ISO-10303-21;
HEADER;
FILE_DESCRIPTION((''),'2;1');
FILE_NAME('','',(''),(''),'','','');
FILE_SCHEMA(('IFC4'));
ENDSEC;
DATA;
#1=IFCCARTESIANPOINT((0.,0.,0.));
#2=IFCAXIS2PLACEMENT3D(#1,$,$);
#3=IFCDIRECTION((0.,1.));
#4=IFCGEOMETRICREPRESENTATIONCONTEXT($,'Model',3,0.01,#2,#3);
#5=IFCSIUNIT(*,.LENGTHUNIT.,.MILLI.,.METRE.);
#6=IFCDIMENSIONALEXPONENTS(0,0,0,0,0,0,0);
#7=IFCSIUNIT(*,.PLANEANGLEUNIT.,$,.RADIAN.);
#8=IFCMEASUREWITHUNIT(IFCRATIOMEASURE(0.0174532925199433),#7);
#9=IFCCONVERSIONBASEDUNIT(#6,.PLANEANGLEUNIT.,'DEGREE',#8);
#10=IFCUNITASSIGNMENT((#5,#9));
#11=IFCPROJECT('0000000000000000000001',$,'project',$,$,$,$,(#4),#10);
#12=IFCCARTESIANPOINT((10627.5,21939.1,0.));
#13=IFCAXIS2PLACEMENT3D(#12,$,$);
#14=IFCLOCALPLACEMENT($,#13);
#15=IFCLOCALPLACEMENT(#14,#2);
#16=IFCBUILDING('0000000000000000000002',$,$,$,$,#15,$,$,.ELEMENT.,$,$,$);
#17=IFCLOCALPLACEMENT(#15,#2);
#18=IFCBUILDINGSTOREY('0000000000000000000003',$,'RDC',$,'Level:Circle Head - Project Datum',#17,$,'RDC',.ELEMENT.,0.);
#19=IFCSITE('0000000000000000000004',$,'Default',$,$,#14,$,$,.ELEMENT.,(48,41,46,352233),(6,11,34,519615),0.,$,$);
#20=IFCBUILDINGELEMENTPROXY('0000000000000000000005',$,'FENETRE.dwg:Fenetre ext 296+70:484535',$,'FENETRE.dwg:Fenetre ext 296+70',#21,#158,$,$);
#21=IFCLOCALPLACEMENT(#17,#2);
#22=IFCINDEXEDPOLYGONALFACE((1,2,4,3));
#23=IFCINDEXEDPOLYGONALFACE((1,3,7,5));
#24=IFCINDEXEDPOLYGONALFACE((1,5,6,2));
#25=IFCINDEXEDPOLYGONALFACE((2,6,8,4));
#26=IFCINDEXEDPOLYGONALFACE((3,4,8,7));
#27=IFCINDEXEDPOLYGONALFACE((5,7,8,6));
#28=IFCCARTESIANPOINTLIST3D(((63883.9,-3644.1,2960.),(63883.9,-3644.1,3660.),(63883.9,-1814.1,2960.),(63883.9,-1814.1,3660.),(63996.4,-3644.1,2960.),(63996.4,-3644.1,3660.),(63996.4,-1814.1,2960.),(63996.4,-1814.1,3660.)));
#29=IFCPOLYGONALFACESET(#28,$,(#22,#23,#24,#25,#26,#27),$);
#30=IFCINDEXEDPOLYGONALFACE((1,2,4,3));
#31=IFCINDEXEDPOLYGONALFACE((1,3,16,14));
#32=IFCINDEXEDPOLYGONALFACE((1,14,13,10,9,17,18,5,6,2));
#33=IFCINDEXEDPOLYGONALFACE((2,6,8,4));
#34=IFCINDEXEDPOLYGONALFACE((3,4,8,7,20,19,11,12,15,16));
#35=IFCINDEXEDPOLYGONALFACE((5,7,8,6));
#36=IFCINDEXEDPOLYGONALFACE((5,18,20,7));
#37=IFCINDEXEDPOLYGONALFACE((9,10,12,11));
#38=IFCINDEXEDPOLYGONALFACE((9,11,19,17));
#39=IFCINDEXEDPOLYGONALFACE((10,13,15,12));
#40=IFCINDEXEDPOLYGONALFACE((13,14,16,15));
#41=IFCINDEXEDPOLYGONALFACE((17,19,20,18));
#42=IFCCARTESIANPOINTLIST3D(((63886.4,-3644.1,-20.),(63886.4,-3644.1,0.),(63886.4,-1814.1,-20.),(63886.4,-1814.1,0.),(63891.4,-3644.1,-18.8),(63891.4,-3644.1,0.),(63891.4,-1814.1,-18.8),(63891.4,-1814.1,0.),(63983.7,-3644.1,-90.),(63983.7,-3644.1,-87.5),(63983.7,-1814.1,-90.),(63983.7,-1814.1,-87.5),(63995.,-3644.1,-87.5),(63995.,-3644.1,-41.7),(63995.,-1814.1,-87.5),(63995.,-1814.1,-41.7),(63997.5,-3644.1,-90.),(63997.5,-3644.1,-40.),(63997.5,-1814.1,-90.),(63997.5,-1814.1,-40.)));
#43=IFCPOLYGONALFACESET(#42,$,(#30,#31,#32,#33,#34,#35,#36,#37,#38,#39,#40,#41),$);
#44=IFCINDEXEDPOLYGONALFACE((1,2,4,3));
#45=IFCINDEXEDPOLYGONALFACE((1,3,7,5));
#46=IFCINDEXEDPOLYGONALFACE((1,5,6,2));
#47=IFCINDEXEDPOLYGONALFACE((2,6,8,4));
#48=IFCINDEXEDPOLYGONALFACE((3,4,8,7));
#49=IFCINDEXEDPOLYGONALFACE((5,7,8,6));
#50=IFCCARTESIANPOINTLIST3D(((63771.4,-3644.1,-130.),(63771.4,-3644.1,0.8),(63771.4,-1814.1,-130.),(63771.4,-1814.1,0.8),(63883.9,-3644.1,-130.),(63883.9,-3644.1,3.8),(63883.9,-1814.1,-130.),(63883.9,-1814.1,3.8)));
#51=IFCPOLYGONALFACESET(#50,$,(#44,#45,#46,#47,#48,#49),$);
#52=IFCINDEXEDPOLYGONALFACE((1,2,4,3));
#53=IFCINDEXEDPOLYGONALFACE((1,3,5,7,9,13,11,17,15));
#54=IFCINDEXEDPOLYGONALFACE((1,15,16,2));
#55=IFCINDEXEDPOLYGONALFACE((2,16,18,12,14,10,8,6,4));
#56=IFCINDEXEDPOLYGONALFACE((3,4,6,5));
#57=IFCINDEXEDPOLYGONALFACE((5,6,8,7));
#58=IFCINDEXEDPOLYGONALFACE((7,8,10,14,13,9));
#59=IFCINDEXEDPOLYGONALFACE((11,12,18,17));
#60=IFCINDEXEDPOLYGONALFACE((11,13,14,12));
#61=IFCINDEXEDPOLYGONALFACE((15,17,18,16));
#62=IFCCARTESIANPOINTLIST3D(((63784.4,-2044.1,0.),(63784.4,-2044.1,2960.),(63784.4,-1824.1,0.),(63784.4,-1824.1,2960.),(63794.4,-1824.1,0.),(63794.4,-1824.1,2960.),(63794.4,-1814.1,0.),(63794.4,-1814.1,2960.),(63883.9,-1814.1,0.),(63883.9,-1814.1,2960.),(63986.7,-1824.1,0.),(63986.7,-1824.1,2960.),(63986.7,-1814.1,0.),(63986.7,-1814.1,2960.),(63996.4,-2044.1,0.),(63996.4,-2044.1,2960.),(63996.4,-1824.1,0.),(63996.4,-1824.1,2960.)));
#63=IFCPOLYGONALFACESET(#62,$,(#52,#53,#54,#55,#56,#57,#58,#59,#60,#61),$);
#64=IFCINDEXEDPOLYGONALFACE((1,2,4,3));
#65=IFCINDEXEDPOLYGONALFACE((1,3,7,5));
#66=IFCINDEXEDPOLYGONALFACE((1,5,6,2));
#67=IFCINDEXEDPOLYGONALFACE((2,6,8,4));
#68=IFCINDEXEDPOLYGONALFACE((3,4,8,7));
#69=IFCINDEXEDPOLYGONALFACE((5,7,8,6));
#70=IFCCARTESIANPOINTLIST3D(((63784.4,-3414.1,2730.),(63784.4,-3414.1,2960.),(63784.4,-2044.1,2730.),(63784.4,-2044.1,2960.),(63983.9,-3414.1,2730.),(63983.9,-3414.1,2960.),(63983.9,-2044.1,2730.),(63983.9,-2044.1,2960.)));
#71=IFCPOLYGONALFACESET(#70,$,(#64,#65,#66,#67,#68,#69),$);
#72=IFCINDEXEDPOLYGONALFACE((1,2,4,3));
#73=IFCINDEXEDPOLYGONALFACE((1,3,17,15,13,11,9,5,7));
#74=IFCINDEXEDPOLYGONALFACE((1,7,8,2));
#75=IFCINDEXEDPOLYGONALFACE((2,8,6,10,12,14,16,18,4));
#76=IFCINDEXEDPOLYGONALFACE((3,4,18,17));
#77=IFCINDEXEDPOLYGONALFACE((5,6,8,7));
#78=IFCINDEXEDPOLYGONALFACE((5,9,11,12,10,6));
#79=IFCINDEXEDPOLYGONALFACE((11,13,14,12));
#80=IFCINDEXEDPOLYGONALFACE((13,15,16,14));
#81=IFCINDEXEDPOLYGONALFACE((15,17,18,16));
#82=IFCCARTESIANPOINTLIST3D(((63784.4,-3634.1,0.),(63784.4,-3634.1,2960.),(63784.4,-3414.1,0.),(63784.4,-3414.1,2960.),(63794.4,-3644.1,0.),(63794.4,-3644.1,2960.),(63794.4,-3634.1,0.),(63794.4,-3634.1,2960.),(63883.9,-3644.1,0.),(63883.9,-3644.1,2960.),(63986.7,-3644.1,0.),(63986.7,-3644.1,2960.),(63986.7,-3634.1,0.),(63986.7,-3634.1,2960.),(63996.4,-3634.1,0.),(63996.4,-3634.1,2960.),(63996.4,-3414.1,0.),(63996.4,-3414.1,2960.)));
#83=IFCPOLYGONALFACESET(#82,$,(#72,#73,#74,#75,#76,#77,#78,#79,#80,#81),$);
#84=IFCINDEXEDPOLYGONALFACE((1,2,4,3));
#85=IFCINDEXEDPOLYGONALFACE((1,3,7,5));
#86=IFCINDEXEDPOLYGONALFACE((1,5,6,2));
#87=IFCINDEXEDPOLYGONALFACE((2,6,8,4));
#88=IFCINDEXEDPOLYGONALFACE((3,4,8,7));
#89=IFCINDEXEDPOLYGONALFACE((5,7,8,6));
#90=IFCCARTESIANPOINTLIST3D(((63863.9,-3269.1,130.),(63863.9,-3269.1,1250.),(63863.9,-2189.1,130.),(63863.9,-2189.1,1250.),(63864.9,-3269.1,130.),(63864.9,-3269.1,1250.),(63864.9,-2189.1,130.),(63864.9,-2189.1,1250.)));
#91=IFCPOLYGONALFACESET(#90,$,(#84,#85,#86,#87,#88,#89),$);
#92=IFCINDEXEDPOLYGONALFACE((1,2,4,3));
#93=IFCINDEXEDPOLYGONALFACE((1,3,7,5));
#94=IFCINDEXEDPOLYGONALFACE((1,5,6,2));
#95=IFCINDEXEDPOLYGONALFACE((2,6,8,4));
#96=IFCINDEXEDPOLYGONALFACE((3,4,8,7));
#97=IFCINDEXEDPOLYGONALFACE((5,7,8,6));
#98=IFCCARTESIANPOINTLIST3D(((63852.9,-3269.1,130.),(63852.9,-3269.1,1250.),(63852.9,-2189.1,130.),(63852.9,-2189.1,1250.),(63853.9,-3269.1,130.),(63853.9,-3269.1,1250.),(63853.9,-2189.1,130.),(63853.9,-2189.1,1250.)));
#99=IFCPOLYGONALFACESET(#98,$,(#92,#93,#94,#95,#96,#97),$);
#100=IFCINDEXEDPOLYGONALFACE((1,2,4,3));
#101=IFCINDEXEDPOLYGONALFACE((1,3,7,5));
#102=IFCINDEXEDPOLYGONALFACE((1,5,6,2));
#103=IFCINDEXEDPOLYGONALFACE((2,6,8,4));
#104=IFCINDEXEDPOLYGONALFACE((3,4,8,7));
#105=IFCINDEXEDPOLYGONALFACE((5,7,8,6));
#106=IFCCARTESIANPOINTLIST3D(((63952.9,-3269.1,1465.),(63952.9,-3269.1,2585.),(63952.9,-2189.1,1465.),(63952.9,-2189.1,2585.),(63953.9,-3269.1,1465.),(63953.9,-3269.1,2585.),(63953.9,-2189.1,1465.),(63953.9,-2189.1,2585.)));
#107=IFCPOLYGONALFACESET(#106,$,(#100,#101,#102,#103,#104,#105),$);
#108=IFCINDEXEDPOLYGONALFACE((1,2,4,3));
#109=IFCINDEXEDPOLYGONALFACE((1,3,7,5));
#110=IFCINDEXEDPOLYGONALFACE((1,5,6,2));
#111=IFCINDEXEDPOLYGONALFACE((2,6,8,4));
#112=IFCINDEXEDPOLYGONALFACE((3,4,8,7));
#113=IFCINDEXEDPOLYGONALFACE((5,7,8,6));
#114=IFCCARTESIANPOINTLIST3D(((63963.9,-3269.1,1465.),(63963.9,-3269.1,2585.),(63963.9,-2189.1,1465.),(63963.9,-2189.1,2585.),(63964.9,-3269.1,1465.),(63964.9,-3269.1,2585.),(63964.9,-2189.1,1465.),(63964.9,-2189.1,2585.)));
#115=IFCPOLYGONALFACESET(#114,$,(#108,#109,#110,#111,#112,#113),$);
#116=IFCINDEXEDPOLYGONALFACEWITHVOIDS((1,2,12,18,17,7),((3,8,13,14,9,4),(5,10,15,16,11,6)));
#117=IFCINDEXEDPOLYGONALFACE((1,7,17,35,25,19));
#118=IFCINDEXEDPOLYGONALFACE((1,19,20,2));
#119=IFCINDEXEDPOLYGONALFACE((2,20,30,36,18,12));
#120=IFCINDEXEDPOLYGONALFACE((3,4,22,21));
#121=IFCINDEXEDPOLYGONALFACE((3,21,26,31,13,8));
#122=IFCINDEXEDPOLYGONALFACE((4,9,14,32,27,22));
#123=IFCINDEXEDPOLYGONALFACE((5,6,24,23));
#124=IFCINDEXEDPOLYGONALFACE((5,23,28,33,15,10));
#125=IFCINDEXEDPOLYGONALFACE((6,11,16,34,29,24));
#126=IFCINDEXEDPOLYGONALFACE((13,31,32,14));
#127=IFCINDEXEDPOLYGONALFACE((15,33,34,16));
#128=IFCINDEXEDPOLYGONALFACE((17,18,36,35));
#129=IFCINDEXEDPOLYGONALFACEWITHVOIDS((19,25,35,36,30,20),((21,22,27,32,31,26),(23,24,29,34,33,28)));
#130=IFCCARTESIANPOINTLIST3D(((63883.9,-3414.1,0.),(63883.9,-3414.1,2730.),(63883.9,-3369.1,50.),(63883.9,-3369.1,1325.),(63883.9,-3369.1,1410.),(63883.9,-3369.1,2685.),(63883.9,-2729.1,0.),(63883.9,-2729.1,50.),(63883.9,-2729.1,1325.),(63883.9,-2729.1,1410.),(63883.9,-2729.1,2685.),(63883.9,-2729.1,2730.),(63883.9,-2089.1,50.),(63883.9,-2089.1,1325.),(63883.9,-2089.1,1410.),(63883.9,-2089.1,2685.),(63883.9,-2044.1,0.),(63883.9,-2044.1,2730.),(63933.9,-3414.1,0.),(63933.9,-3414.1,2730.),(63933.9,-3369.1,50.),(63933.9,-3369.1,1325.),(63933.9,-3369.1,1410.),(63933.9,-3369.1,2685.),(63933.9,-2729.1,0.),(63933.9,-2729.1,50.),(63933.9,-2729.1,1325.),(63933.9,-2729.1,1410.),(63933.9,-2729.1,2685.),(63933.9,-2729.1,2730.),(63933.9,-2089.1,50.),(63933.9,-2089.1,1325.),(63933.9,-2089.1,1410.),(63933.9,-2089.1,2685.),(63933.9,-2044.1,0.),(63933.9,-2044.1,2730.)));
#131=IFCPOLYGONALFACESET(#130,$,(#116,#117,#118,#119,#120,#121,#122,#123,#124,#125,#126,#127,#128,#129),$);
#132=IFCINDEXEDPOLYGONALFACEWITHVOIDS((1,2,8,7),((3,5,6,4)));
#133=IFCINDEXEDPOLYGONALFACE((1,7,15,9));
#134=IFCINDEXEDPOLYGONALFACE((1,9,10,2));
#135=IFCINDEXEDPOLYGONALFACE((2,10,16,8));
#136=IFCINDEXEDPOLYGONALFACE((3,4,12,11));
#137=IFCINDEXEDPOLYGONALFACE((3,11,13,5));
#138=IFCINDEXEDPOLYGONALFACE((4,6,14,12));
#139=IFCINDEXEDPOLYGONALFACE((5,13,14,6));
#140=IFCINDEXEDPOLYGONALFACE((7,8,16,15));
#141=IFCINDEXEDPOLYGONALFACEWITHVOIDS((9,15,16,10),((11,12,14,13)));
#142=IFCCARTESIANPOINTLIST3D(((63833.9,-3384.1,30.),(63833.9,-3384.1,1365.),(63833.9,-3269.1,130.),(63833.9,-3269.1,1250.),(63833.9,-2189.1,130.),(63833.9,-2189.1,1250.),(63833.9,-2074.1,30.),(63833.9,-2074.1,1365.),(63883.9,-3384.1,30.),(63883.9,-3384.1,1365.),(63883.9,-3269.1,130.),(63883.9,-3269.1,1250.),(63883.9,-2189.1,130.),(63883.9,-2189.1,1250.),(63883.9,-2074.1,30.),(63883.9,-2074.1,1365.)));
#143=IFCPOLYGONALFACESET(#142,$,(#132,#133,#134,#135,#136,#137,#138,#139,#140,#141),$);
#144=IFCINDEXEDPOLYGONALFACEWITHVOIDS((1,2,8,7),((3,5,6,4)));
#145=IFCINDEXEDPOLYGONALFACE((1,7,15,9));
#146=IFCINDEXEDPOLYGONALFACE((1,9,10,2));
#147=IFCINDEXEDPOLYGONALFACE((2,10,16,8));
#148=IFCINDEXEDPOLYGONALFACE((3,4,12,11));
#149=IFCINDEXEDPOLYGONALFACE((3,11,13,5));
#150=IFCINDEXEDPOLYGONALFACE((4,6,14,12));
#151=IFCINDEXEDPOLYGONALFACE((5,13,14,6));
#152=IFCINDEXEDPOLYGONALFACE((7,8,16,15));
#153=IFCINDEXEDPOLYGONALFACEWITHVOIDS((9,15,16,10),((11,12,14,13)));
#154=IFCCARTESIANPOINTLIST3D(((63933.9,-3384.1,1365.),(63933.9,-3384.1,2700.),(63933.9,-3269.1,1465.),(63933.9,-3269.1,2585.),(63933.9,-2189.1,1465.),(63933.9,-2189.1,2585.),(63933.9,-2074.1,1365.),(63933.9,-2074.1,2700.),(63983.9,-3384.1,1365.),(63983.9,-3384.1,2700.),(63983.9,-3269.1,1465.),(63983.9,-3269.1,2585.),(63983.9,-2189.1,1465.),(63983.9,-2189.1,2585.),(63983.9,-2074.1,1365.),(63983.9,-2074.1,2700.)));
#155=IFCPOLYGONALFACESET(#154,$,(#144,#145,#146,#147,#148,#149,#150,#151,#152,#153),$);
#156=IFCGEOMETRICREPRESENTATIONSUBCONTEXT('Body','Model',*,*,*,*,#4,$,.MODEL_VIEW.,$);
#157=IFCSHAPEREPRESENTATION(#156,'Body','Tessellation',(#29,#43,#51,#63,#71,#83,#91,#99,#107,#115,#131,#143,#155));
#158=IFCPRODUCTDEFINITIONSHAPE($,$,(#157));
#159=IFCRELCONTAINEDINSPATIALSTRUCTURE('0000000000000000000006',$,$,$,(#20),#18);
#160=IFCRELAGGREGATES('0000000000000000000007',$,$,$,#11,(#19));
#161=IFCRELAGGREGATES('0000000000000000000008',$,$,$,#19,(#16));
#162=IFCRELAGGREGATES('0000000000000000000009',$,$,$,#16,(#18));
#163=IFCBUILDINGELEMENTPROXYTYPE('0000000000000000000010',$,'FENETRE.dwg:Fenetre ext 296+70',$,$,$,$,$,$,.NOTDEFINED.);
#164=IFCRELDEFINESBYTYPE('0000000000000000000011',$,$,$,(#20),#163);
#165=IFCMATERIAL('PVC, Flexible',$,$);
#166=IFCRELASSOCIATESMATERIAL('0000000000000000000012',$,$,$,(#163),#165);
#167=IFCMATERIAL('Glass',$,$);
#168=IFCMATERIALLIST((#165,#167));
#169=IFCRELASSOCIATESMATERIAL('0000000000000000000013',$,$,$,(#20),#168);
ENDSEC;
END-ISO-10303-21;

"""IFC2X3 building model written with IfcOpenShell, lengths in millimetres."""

from ifc_helpers import new_model, entity, si_unit, converted_unit, direction, frame, frame_2d, origin, origin_2d_with_axis, place, context, subcontext, project, spatial, polyline, rectangle, outline, extrude, source, transform, mapped, material, material_list, type_object, type_shapes, element, save


model = new_model("IFC2X3")

# Units and contexts
model_context = context("Model", 3, precision=0.01, world=origin(), true_north=direction((0.0, 1.0)))
body_context = subcontext(model_context, "Body", "Model", "MODEL_VIEW")
ifc_project = project(units=[si_unit("LENGTHUNIT", "METRE", prefix="MILLI"), converted_unit("PLANEANGLEUNIT", "DEGREE", entity("IfcRatioMeasure", 0.0174532925199433), si_unit("PLANEANGLEUNIT", "RADIAN"), dimensions=[0, 0, 0, 0, 0, 0, 0])], contexts=[model_context])

# Site, building, storey
site_placement = place(None, frame((10627.5, 21939.1, 0.0)))
site = spatial("IfcSite", under=ifc_project, at=site_placement, Name="Default", CompositionType="ELEMENT", RefLatitude=(48, 41, 46, 352233), RefLongitude=(6, 11, 34, 519615), RefElevation=0.0)
building_placement = place(site_placement, origin())
building = spatial("IfcBuilding", under=site, at=building_placement, CompositionType="ELEMENT")
storey_placement = place(building_placement, origin())
storey = spatial("IfcBuildingStorey", under=building, at=storey_placement, Name="RDC", ObjectType="Level:Circle Head - Project Datum", LongName="RDC", CompositionType="ELEMENT", Elevation=0.0)

# Building element proxy
ifc_material_1 = material(Name="PVC, Flexible")
ifc_material_2 = material(Name="Glass")
building_element_proxy_type_1 = type_object("IfcBuildingElementProxyType", Name="FENETRE.dwg:Fenetre ext 296+70", PredefinedType="NOTDEFINED", material=ifc_material_1)
shared_shape_1 = source(origin(), body_context, "Body", "SweptSolid", [
    extrude(rectangle(XDim=112.5, YDim=1830.0, at=origin_2d_with_axis()), frame((-10.4, -56.3, 2960.0), z_axis=(0.0, 0.0, 1.0), x_axis=(0.0, 1.0, 0.0)), (0.0, 0.0, 1.0), 700.0),
    extrude(outline(polyline([(27.5, -64.4), (47.5, -64.4), (47.5, -59.4), (28.8, -59.4), (7.5, 46.7), (-42.5, 46.7), (-42.5, 32.9), (-40.0, 32.9), (-40.0, 44.2), (5.8, 44.2), (27.5, -64.4)])), frame((-925.4, -66.9, -47.5), z_axis=(1.0, 0.0, 0.0), x_axis=(0.0, 0.0, 1.0)), (0.0, 0.0, 1.0), 1830.0),
    extrude(outline(polyline([(-54.5, -66.1), (58.0, -66.1), (54.5, 67.6), (-58.0, 64.6), (-54.5, -66.1)])), frame((-925.4, 56.3, -63.8), z_axis=(1.0, 0.0, 0.0), x_axis=(0.0, -0.999645, 0.02665)), (0.0, 0.0, 1.0), 1830.0),
    extrude(outline(polyline([(-97.0, -55.6), (5.9, -55.6), (95.4, -55.6), (95.4, -45.6), (105.4, -45.6), (105.4, 174.4), (-106.6, 174.4), (-106.6, -45.6), (-97.0, -45.6), (-97.0, -55.6)])), frame((849.0, -5.9, 0.0), z_axis=(0.0, 0.0, 1.0), x_axis=(0.0, 1.0, 0.0)), (0.0, 0.0, 1.0), 2960.0),
    extrude(rectangle(XDim=1370.0, YDim=199.5, at=origin_2d_with_axis()), frame((-10.4, -0.3, 2730.0), z_axis=(0.0, 0.0, 1.0), x_axis=(-1.0, 0.0, 0.0)), (0.0, 0.0, 1.0), 230.0),
    extrude(outline(polyline([(-55.6, 97.0), (-55.6, -5.9), (-55.6, -95.4), (-45.6, -95.4), (-45.6, -105.4), (174.4, -105.4), (174.4, 106.6), (-45.6, 106.6), (-45.6, 97.0), (-55.6, 97.0)])), frame((-869.9, -5.9, 0.0), z_axis=(0.0, 0.0, -1.0), x_axis=(1.0, 0.0, 0.0)), (0.0, 0.0, -1.0), 2960.0),
    extrude(rectangle(XDim=1080.0, YDim=1.0, at=origin_2d_with_axis()), frame((-10.4, 19.5, 130.0), z_axis=(0.0, 0.0, 1.0), x_axis=(-1.0, 0.0, 0.0)), (0.0, 0.0, 1.0), 1120.0),
    extrude(rectangle(XDim=1080.0, YDim=1.0, at=origin_2d_with_axis()), frame((-10.4, 30.5, 130.0), z_axis=(0.0, 0.0, 1.0), x_axis=(-1.0, 0.0, 0.0)), (0.0, 0.0, 1.0), 1120.0),
    extrude(rectangle(XDim=1080.0, YDim=1.0, at=frame_2d((0.0, 0.0), x_axis=(1.0, 0.0))), frame((-10.4, -69.5, 1465.0), z_axis=(0.0, 0.0, 1.0), x_axis=(-1.0, 0.0, 0.0)), (0.0, 0.0, 1.0), 1120.0),
    extrude(rectangle(XDim=1080.0, YDim=1.0, at=frame_2d((0.0, 0.0), x_axis=(1.0, 0.0))), frame((-10.4, -80.5, 1465.0), z_axis=(0.0, 0.0, 1.0), x_axis=(-1.0, 0.0, 0.0)), (0.0, 0.0, 1.0), 1120.0),
    extrude(outline(polyline([(-685.0, -1365.0), (0.0, -1365.0), (685.0, -1365.0), (685.0, 1365.0), (0.0, 1365.0), (-685.0, 1365.0), (-685.0, -1365.0)]), holes=[polyline([(-640.0, -1320.0), (-640.0, -45.0), (0.0, -45.0), (640.0, -45.0), (640.0, -1320.0), (0.0, -1320.0), (-640.0, -1320.0)]), polyline([(-640.0, 40.0), (-640.0, 1315.0), (0.0, 1315.0), (640.0, 1315.0), (640.0, 40.0), (0.0, 40.0), (-640.0, 40.0)])]), frame((-10.4, -50.0, 1365.0), z_axis=(0.0, 1.0, 0.0), x_axis=(1.0, 0.0, 0.0)), (0.0, 0.0, 1.0), 50.0),
    extrude(outline(polyline([(-655.0, -667.5), (655.0, -667.5), (655.0, 667.5), (-655.0, 667.5), (-655.0, -667.5)]), holes=[polyline([(-540.0, 552.5), (540.0, 552.5), (540.0, -567.5), (-540.0, -567.5), (-540.0, 552.5)])]), frame((-10.4, 0.0, 697.5), z_axis=(0.0, 1.0, 0.0), x_axis=(-1.0, 0.0, 0.0)), (0.0, 0.0, 1.0), 50.0),
    extrude(outline(polyline([(-655.0, -667.5), (655.0, -667.5), (655.0, 667.5), (-655.0, 667.5), (-655.0, -667.5)]), holes=[polyline([(-540.0, 552.5), (540.0, 552.5), (540.0, -567.5), (-540.0, -567.5), (-540.0, 552.5)])]), frame((-10.4, -100.0, 2032.5), z_axis=(0.0, 1.0, 0.0), x_axis=(-1.0, 0.0, 0.0)), (0.0, 0.0, 1.0), 50.0),
])
type_shapes(building_element_proxy_type_1, [shared_shape_1])
ifc_material_list_1 = material_list([ifc_material_1, ifc_material_2])
proxy_1_placement = place(storey_placement, frame((63883.9, -2718.7, 0.0), z_axis=(0.0, 0.0, 1.0), x_axis=(0.0, 1.0, 0.0)))
element("IfcBuildingElementProxy", 1, at=proxy_1_placement, inside=storey, type_object=building_element_proxy_type_1, material=ifc_material_list_1, Name="FENETRE.dwg:Fenetre ext 296+70:484535", ObjectType="FENETRE.dwg:Fenetre ext 296+70", context=body_context, shape_type="MappedRepresentation", body=[
    mapped(shared_shape_1, transform((0.0, 0.0, 0.0), scale=1.0)),
])

save(model, "model.ifc")
